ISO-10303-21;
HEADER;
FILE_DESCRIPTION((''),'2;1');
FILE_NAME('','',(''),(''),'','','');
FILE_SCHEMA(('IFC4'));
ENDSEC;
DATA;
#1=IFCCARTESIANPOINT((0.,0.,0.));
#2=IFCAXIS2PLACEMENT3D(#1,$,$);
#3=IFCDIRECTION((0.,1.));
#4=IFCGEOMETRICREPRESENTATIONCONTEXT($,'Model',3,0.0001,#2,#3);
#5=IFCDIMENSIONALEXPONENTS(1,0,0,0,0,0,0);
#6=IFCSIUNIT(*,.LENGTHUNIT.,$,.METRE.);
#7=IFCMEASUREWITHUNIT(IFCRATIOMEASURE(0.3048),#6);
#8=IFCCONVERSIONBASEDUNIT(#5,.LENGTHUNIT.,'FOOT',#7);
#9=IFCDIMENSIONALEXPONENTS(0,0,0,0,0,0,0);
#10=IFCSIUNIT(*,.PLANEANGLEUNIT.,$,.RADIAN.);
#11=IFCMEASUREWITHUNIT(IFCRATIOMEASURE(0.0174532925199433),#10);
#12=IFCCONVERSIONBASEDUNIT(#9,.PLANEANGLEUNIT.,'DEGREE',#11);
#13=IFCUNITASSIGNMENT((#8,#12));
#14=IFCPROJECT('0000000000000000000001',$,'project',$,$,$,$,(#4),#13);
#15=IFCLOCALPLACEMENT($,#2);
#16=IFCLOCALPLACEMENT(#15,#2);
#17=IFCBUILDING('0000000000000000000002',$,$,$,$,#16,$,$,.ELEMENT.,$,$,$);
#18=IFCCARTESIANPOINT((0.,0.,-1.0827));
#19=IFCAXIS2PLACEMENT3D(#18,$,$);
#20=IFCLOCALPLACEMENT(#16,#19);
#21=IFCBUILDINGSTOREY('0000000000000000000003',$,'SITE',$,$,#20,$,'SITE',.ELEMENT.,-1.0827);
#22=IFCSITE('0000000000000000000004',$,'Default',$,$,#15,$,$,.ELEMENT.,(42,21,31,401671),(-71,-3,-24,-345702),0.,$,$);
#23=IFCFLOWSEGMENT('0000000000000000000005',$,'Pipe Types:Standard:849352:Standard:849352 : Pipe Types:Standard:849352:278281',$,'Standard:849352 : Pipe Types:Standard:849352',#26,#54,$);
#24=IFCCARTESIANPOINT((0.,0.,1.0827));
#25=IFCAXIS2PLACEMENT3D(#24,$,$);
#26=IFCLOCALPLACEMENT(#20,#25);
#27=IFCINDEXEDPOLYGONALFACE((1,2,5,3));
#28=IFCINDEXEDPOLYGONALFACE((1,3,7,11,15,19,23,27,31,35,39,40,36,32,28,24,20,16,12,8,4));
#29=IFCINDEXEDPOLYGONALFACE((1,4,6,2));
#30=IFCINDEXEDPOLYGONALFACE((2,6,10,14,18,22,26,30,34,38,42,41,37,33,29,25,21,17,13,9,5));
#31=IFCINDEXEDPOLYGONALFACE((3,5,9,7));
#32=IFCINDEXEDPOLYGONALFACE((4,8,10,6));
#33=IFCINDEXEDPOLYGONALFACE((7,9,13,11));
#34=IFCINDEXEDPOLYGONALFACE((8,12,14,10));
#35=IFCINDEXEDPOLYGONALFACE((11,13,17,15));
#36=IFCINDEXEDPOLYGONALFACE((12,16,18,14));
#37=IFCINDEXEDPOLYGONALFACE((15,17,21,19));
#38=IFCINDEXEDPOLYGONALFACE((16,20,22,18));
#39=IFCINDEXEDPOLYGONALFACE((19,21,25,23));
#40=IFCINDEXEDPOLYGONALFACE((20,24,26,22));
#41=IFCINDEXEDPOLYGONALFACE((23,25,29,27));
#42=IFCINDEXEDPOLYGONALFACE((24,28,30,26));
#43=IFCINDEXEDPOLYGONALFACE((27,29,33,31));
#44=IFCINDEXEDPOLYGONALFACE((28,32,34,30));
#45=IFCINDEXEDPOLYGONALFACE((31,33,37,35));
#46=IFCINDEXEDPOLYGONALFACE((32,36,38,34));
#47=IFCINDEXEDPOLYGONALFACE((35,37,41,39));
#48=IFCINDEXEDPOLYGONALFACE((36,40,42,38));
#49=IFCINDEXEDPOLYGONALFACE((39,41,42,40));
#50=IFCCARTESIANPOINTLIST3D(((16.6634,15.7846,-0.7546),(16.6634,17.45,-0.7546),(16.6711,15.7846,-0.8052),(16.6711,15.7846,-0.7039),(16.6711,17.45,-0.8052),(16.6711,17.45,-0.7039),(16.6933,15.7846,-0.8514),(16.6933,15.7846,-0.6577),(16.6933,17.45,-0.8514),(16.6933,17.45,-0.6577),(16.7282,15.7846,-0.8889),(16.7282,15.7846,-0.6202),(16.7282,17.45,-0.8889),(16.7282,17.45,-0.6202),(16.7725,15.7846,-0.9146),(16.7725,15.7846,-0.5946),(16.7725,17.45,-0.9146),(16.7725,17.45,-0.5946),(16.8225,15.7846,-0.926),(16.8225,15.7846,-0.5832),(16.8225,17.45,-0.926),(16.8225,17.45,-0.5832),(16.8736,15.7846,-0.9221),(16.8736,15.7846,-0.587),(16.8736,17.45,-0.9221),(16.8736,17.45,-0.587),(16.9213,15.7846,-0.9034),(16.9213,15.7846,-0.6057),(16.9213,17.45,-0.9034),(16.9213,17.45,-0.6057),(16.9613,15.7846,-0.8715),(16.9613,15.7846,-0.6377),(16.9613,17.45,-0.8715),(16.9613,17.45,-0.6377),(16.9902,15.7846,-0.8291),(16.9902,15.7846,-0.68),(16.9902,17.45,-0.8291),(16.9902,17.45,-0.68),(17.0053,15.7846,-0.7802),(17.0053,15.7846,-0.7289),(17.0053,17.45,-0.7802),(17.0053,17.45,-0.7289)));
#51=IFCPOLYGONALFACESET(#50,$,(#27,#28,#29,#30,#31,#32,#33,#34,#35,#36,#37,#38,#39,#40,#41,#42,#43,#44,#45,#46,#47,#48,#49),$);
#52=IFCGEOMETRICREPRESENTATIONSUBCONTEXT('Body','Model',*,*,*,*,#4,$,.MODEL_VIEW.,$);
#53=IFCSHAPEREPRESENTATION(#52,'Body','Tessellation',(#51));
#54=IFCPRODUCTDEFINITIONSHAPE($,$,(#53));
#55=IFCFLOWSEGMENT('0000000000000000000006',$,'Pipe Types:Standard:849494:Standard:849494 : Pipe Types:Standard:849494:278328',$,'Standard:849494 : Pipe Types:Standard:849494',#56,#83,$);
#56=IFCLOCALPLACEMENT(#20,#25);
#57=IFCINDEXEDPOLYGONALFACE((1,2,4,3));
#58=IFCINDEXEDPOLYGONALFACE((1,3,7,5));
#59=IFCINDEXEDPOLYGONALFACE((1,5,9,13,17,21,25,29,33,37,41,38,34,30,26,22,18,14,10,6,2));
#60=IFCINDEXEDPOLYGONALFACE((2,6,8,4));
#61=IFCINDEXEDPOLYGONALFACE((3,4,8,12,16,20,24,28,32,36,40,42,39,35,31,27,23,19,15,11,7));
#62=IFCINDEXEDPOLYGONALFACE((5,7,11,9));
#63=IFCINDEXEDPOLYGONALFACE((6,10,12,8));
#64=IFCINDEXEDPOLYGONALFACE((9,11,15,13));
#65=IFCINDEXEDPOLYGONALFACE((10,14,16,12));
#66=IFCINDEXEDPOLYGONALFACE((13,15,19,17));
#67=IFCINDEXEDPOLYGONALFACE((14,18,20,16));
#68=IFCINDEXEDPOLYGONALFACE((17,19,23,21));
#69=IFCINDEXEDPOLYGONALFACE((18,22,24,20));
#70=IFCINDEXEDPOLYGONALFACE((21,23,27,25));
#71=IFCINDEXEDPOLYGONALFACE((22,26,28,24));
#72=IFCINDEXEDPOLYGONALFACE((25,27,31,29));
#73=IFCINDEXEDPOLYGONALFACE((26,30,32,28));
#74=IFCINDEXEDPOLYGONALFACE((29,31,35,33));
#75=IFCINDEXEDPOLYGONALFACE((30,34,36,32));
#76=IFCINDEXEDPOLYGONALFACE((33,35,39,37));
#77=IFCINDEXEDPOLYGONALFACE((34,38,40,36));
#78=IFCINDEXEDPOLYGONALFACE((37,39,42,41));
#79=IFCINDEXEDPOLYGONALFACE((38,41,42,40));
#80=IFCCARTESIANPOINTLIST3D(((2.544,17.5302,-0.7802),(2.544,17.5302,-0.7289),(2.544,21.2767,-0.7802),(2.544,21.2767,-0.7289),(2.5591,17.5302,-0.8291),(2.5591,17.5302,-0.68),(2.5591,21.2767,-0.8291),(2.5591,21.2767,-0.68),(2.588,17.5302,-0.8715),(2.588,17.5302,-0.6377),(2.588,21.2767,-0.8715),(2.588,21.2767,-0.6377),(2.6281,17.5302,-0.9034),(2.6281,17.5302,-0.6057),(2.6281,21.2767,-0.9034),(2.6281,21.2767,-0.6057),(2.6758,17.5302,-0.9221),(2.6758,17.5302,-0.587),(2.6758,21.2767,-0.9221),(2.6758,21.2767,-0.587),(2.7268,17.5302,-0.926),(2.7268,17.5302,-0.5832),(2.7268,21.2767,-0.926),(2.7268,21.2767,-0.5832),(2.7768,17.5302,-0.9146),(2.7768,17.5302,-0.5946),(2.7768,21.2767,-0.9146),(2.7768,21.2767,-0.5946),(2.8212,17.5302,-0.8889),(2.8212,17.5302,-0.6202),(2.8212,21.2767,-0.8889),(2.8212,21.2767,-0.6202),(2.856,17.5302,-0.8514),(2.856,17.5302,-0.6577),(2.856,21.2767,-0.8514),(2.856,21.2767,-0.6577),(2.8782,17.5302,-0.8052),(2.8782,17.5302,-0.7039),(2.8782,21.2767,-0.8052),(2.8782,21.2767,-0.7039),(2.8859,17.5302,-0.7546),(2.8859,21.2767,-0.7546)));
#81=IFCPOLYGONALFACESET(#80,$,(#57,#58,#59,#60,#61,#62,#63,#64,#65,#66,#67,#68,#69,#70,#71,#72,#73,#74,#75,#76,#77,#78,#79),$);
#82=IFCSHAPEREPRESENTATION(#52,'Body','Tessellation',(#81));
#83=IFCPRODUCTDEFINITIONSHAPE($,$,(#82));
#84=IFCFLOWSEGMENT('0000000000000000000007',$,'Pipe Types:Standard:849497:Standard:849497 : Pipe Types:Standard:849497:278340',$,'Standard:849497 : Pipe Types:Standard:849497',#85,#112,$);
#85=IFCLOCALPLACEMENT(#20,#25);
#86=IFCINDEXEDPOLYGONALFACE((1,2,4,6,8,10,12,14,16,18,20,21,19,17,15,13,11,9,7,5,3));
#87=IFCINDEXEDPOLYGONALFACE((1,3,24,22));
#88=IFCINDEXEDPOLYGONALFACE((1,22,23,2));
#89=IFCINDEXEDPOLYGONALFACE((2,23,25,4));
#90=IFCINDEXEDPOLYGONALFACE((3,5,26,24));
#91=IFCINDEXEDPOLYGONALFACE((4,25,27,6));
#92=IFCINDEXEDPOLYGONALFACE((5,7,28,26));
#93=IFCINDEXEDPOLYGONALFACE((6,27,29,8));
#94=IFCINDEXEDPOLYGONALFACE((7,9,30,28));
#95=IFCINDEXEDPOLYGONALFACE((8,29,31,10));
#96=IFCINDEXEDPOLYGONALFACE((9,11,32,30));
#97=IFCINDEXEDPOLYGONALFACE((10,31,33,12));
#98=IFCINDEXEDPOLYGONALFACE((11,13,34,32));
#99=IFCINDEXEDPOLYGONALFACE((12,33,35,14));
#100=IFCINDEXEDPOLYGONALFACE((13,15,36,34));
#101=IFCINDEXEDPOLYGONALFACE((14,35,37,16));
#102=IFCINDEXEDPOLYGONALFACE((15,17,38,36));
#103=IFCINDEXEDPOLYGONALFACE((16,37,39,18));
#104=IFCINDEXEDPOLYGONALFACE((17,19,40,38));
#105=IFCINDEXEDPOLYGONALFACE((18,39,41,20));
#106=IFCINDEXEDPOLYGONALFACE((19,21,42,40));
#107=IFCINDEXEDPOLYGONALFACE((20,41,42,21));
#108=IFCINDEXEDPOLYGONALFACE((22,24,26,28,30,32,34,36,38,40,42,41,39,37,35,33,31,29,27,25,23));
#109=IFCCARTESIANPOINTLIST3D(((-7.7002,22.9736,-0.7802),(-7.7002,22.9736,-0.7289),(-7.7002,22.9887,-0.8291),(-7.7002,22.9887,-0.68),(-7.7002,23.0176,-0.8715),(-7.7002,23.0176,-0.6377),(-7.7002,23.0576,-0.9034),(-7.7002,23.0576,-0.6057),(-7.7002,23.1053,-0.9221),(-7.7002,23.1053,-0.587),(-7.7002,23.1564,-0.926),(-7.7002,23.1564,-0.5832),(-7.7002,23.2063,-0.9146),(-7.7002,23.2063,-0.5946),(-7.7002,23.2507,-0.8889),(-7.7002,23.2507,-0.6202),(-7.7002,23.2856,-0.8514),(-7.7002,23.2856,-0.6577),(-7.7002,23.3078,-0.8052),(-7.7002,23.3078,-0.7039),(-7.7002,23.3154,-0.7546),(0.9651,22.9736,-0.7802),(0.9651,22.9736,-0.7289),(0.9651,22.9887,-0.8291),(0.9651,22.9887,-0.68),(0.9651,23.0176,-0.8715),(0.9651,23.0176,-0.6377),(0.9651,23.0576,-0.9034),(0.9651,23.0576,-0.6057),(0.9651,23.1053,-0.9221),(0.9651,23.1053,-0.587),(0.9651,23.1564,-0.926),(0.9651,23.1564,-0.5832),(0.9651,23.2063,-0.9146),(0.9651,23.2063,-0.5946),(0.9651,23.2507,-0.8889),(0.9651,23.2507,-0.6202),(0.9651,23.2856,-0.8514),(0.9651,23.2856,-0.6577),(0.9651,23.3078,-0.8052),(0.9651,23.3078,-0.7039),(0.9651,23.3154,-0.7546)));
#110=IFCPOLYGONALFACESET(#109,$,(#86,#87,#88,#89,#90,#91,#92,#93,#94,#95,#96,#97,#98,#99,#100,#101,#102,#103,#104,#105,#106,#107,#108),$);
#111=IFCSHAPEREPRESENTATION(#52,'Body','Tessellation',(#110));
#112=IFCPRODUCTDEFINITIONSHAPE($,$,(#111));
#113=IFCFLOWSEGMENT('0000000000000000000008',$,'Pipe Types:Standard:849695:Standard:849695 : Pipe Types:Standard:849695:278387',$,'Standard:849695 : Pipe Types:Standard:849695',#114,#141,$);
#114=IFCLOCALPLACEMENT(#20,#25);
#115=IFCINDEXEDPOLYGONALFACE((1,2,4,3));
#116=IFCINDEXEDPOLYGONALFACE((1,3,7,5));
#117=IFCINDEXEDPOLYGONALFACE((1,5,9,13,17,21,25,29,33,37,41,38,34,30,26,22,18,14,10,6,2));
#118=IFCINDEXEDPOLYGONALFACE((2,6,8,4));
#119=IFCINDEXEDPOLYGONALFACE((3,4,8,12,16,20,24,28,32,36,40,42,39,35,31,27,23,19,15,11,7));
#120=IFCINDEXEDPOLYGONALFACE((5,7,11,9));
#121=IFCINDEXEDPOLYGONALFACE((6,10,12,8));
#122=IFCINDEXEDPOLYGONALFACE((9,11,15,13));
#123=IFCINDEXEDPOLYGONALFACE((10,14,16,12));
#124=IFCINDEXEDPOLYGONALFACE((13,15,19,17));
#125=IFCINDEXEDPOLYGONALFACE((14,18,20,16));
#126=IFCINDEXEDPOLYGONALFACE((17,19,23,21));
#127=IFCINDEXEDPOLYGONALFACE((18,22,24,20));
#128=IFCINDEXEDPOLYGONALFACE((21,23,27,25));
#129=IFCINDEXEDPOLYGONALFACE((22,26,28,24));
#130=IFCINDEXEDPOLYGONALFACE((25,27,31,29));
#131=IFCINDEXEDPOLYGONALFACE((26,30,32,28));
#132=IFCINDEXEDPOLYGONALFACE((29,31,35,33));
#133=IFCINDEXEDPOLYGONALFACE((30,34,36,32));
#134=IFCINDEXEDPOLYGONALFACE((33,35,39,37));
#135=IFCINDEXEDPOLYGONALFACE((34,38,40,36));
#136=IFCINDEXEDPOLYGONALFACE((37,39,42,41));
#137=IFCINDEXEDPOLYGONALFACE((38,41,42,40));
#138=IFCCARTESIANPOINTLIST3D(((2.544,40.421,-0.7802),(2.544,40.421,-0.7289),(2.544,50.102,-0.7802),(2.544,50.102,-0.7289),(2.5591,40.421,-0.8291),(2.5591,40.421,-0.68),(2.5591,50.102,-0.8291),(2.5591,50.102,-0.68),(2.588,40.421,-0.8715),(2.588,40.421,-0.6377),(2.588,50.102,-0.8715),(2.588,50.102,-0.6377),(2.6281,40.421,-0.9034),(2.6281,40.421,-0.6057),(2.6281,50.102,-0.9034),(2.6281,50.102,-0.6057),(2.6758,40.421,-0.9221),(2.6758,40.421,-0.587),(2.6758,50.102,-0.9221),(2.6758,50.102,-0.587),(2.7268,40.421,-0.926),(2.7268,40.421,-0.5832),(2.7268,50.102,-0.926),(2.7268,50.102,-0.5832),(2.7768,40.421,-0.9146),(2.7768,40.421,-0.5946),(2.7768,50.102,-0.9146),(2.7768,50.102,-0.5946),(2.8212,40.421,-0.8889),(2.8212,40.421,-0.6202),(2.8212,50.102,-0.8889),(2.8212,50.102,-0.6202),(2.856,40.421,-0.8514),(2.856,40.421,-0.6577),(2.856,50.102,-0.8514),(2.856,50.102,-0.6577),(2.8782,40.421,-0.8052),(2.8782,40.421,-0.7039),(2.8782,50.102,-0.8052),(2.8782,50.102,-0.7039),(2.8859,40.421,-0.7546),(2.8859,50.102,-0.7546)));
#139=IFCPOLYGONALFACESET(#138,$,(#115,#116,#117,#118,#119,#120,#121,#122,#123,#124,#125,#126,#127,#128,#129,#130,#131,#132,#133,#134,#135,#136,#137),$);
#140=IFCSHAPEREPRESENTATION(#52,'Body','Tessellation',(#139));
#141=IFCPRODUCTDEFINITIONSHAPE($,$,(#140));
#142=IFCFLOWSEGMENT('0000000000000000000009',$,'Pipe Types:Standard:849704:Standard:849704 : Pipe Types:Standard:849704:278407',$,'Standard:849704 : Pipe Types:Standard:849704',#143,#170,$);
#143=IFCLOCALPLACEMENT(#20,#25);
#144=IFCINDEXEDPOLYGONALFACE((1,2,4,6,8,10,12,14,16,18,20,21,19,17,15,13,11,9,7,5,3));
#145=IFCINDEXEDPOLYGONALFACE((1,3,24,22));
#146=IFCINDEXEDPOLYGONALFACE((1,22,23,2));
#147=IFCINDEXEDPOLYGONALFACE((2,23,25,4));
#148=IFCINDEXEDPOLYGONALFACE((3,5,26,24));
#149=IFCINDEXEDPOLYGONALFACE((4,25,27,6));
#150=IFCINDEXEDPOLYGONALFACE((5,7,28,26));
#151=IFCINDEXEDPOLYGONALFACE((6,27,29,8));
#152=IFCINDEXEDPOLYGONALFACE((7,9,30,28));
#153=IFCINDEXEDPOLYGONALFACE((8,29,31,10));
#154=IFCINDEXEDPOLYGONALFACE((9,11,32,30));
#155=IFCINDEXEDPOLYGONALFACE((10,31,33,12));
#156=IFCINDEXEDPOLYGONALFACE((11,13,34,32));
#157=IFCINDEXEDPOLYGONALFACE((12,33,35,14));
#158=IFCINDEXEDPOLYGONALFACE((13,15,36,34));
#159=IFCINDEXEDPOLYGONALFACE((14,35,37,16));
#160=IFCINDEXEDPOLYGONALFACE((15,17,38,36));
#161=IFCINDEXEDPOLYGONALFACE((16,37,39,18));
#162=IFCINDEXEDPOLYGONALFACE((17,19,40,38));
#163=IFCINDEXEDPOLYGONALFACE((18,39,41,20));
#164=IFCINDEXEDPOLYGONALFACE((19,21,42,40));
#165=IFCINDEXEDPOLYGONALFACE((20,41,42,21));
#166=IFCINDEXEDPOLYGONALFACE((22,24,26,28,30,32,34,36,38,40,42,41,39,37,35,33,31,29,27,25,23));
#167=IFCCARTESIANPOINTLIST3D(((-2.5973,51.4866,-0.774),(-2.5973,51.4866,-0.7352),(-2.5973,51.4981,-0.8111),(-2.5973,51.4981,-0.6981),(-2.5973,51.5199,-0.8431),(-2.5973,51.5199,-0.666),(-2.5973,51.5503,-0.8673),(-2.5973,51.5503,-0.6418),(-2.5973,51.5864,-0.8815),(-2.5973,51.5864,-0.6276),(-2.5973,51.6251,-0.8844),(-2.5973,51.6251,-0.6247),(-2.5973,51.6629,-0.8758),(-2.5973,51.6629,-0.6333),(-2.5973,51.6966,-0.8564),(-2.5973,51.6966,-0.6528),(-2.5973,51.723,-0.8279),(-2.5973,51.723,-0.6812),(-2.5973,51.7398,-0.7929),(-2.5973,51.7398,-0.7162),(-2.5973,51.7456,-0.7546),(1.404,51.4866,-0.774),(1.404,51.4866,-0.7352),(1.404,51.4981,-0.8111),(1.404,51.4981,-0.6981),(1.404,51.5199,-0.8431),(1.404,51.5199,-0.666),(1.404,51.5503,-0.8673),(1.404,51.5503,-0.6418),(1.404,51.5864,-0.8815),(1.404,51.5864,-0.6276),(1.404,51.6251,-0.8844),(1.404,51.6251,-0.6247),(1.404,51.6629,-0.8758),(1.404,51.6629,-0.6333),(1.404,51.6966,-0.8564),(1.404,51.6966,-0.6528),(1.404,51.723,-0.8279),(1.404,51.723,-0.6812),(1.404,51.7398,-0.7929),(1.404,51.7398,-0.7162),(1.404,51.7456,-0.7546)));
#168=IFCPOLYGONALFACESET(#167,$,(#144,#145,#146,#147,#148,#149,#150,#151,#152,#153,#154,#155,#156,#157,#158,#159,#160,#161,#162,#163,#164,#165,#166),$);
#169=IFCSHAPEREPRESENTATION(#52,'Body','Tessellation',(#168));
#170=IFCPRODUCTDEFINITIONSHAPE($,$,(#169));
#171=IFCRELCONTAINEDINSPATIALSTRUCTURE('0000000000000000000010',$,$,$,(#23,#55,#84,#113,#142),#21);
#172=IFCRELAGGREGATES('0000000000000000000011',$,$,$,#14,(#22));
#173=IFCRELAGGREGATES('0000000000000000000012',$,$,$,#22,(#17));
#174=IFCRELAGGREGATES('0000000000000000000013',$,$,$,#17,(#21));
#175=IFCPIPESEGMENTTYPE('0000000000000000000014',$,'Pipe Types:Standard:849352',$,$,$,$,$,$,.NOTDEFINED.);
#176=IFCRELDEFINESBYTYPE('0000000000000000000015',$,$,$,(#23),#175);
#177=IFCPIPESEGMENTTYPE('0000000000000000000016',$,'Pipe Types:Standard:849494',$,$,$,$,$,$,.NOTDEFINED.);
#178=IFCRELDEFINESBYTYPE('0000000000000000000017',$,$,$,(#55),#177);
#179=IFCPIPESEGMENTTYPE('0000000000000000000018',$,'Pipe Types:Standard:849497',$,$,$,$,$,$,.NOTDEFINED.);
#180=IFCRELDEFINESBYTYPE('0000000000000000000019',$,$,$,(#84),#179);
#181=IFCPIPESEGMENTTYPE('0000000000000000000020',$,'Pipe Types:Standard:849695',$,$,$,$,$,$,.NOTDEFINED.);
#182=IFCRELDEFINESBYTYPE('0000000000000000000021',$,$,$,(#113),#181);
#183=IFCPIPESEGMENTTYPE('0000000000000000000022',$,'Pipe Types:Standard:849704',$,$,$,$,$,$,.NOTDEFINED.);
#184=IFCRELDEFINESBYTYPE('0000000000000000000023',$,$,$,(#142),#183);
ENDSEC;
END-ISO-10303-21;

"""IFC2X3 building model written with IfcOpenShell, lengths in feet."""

from ifc_helpers import new_model, entity, si_unit, converted_unit, direction, frame, frame_2d, origin, place, context, subcontext, project, spatial, circle, extrude, source, transform, mapped, type_object, type_shapes, element, save


model = new_model("IFC2X3")

# Units and contexts
model_context = context("Model", 3, precision=0.0001, world=origin(), true_north=direction((0.0, 1.0)))
body_context = subcontext(model_context, "Body", "Model", "MODEL_VIEW")
ifc_project = project(units=[converted_unit("LENGTHUNIT", "FOOT", entity("IfcRatioMeasure", 0.3048), si_unit("LENGTHUNIT", "METRE"), dimensions=[1, 0, 0, 0, 0, 0, 0]), converted_unit("PLANEANGLEUNIT", "DEGREE", entity("IfcRatioMeasure", 0.0174532925199433), si_unit("PLANEANGLEUNIT", "RADIAN"), dimensions=[0, 0, 0, 0, 0, 0, 0])], contexts=[model_context])

# Site, building, storey
site_placement = place(None, origin())
site = spatial("IfcSite", under=ifc_project, at=site_placement, Name="Default", CompositionType="ELEMENT", RefLatitude=(42, 21, 31, 401671), RefLongitude=(-71, -3, -24, -345702), RefElevation=0.0)
building_placement = place(site_placement, origin())
building = spatial("IfcBuilding", under=site, at=building_placement, CompositionType="ELEMENT")
storey_placement = place(building_placement, frame((0.0, 0.0, -1.0827)))
storey = spatial("IfcBuildingStorey", under=building, at=storey_placement, Name="SITE", LongName="SITE", CompositionType="ELEMENT", Elevation=-1.0827)

# Flow segments
pipe_segment_type_1 = type_object("IfcPipeSegmentType", Name="Pipe Types:Standard:849352", PredefinedType="NOTDEFINED")
shared_shape_1 = source(origin(), body_context, "Body", "SweptSolid", [
    extrude(circle(Radius=0.1719, at=frame_2d((0.0, 0.0), x_axis=(1.0, 0.0))), frame((16.8353, 15.7846, -0.7546), z_axis=(0.0, 1.0, 0.0), x_axis=(-1.0, 0.0, 0.0)), (0.0, 0.0, 1.0), 1.6654),
])
type_shapes(pipe_segment_type_1, [shared_shape_1])
flow_segment_1_placement = place(storey_placement, frame((0.0, 0.0, 1.0827)))
element("IfcFlowSegment", 1, at=flow_segment_1_placement, inside=storey, type_object=pipe_segment_type_1, Name="Pipe Types:Standard:849352:Standard:849352 : Pipe Types:Standard:849352:278281", ObjectType="Standard:849352 : Pipe Types:Standard:849352", context=body_context, shape_type="MappedRepresentation", body=[
    mapped(shared_shape_1, transform((0.0, 0.0, 0.0), scale=1.0)),
])
pipe_segment_type_2 = type_object("IfcPipeSegmentType", Name="Pipe Types:Standard:849494", PredefinedType="NOTDEFINED")
shared_shape_2 = source(origin(), body_context, "Body", "SweptSolid", [
    extrude(circle(Radius=0.1719, at=frame_2d((0.0, 0.0), x_axis=(1.0, 0.0))), frame((2.714, 17.5302, -0.7546), z_axis=(0.0, 1.0, 0.0), x_axis=(1.0, 0.0, 0.0)), (0.0, 0.0, 1.0), 3.7465),
])
type_shapes(pipe_segment_type_2, [shared_shape_2])
flow_segment_2_placement = place(storey_placement, frame((0.0, 0.0, 1.0827)))
element("IfcFlowSegment", 2, at=flow_segment_2_placement, inside=storey, type_object=pipe_segment_type_2, Name="Pipe Types:Standard:849494:Standard:849494 : Pipe Types:Standard:849494:278328", ObjectType="Standard:849494 : Pipe Types:Standard:849494", context=body_context, shape_type="MappedRepresentation", body=[
    mapped(shared_shape_2, transform((0.0, 0.0, 0.0), scale=1.0)),
])
pipe_segment_type_3 = type_object("IfcPipeSegmentType", Name="Pipe Types:Standard:849497", PredefinedType="NOTDEFINED")
shared_shape_3 = source(origin(), body_context, "Body", "SweptSolid", [
    extrude(circle(Radius=0.1719, at=frame_2d((0.0, 0.0), x_axis=(1.0, 0.0))), frame((-7.7002, 23.1435, -0.7546), z_axis=(1.0, 0.0, 0.0), x_axis=(0.0, 1.0, 0.0)), (0.0, 0.0, 1.0), 8.6654),
])
type_shapes(pipe_segment_type_3, [shared_shape_3])
flow_segment_3_placement = place(storey_placement, frame((0.0, 0.0, 1.0827)))
element("IfcFlowSegment", 3, at=flow_segment_3_placement, inside=storey, type_object=pipe_segment_type_3, Name="Pipe Types:Standard:849497:Standard:849497 : Pipe Types:Standard:849497:278340", ObjectType="Standard:849497 : Pipe Types:Standard:849497", context=body_context, shape_type="MappedRepresentation", body=[
    mapped(shared_shape_3, transform((0.0, 0.0, 0.0), scale=1.0)),
])
pipe_segment_type_4 = type_object("IfcPipeSegmentType", Name="Pipe Types:Standard:849695", PredefinedType="NOTDEFINED")
shared_shape_4 = source(origin(), body_context, "Body", "SweptSolid", [
    extrude(circle(Radius=0.1719, at=frame_2d((0.0, 0.0), x_axis=(1.0, 0.0))), frame((2.714, 40.421, -0.7546), z_axis=(0.0, 1.0, 0.0), x_axis=(1.0, 0.0, 0.0)), (0.0, 0.0, 1.0), 9.681),
])
type_shapes(pipe_segment_type_4, [shared_shape_4])
flow_segment_4_placement = place(storey_placement, frame((0.0, 0.0, 1.0827)))
element("IfcFlowSegment", 4, at=flow_segment_4_placement, inside=storey, type_object=pipe_segment_type_4, Name="Pipe Types:Standard:849695:Standard:849695 : Pipe Types:Standard:849695:278387", ObjectType="Standard:849695 : Pipe Types:Standard:849695", context=body_context, shape_type="MappedRepresentation", body=[
    mapped(shared_shape_4, transform((0.0, 0.0, 0.0), scale=1.0)),
])
pipe_segment_type_5 = type_object("IfcPipeSegmentType", Name="Pipe Types:Standard:849704", PredefinedType="NOTDEFINED")
shared_shape_5 = source(origin(), body_context, "Body", "SweptSolid", [
    extrude(circle(Radius=0.1302, at=frame_2d((0.0, 0.0), x_axis=(1.0, 0.0))), frame((-2.5973, 51.6154, -0.7546), z_axis=(1.0, 0.0, 0.0), x_axis=(0.0, 1.0, 0.0)), (0.0, 0.0, 1.0), 4.0013),
])
type_shapes(pipe_segment_type_5, [shared_shape_5])
flow_segment_5_placement = place(storey_placement, frame((0.0, 0.0, 1.0827)))
element("IfcFlowSegment", 5, at=flow_segment_5_placement, inside=storey, type_object=pipe_segment_type_5, Name="Pipe Types:Standard:849704:Standard:849704 : Pipe Types:Standard:849704:278407", ObjectType="Standard:849704 : Pipe Types:Standard:849704", context=body_context, shape_type="MappedRepresentation", body=[
    mapped(shared_shape_5, transform((0.0, 0.0, 0.0), scale=1.0)),
])

save(model, "model.ifc")
